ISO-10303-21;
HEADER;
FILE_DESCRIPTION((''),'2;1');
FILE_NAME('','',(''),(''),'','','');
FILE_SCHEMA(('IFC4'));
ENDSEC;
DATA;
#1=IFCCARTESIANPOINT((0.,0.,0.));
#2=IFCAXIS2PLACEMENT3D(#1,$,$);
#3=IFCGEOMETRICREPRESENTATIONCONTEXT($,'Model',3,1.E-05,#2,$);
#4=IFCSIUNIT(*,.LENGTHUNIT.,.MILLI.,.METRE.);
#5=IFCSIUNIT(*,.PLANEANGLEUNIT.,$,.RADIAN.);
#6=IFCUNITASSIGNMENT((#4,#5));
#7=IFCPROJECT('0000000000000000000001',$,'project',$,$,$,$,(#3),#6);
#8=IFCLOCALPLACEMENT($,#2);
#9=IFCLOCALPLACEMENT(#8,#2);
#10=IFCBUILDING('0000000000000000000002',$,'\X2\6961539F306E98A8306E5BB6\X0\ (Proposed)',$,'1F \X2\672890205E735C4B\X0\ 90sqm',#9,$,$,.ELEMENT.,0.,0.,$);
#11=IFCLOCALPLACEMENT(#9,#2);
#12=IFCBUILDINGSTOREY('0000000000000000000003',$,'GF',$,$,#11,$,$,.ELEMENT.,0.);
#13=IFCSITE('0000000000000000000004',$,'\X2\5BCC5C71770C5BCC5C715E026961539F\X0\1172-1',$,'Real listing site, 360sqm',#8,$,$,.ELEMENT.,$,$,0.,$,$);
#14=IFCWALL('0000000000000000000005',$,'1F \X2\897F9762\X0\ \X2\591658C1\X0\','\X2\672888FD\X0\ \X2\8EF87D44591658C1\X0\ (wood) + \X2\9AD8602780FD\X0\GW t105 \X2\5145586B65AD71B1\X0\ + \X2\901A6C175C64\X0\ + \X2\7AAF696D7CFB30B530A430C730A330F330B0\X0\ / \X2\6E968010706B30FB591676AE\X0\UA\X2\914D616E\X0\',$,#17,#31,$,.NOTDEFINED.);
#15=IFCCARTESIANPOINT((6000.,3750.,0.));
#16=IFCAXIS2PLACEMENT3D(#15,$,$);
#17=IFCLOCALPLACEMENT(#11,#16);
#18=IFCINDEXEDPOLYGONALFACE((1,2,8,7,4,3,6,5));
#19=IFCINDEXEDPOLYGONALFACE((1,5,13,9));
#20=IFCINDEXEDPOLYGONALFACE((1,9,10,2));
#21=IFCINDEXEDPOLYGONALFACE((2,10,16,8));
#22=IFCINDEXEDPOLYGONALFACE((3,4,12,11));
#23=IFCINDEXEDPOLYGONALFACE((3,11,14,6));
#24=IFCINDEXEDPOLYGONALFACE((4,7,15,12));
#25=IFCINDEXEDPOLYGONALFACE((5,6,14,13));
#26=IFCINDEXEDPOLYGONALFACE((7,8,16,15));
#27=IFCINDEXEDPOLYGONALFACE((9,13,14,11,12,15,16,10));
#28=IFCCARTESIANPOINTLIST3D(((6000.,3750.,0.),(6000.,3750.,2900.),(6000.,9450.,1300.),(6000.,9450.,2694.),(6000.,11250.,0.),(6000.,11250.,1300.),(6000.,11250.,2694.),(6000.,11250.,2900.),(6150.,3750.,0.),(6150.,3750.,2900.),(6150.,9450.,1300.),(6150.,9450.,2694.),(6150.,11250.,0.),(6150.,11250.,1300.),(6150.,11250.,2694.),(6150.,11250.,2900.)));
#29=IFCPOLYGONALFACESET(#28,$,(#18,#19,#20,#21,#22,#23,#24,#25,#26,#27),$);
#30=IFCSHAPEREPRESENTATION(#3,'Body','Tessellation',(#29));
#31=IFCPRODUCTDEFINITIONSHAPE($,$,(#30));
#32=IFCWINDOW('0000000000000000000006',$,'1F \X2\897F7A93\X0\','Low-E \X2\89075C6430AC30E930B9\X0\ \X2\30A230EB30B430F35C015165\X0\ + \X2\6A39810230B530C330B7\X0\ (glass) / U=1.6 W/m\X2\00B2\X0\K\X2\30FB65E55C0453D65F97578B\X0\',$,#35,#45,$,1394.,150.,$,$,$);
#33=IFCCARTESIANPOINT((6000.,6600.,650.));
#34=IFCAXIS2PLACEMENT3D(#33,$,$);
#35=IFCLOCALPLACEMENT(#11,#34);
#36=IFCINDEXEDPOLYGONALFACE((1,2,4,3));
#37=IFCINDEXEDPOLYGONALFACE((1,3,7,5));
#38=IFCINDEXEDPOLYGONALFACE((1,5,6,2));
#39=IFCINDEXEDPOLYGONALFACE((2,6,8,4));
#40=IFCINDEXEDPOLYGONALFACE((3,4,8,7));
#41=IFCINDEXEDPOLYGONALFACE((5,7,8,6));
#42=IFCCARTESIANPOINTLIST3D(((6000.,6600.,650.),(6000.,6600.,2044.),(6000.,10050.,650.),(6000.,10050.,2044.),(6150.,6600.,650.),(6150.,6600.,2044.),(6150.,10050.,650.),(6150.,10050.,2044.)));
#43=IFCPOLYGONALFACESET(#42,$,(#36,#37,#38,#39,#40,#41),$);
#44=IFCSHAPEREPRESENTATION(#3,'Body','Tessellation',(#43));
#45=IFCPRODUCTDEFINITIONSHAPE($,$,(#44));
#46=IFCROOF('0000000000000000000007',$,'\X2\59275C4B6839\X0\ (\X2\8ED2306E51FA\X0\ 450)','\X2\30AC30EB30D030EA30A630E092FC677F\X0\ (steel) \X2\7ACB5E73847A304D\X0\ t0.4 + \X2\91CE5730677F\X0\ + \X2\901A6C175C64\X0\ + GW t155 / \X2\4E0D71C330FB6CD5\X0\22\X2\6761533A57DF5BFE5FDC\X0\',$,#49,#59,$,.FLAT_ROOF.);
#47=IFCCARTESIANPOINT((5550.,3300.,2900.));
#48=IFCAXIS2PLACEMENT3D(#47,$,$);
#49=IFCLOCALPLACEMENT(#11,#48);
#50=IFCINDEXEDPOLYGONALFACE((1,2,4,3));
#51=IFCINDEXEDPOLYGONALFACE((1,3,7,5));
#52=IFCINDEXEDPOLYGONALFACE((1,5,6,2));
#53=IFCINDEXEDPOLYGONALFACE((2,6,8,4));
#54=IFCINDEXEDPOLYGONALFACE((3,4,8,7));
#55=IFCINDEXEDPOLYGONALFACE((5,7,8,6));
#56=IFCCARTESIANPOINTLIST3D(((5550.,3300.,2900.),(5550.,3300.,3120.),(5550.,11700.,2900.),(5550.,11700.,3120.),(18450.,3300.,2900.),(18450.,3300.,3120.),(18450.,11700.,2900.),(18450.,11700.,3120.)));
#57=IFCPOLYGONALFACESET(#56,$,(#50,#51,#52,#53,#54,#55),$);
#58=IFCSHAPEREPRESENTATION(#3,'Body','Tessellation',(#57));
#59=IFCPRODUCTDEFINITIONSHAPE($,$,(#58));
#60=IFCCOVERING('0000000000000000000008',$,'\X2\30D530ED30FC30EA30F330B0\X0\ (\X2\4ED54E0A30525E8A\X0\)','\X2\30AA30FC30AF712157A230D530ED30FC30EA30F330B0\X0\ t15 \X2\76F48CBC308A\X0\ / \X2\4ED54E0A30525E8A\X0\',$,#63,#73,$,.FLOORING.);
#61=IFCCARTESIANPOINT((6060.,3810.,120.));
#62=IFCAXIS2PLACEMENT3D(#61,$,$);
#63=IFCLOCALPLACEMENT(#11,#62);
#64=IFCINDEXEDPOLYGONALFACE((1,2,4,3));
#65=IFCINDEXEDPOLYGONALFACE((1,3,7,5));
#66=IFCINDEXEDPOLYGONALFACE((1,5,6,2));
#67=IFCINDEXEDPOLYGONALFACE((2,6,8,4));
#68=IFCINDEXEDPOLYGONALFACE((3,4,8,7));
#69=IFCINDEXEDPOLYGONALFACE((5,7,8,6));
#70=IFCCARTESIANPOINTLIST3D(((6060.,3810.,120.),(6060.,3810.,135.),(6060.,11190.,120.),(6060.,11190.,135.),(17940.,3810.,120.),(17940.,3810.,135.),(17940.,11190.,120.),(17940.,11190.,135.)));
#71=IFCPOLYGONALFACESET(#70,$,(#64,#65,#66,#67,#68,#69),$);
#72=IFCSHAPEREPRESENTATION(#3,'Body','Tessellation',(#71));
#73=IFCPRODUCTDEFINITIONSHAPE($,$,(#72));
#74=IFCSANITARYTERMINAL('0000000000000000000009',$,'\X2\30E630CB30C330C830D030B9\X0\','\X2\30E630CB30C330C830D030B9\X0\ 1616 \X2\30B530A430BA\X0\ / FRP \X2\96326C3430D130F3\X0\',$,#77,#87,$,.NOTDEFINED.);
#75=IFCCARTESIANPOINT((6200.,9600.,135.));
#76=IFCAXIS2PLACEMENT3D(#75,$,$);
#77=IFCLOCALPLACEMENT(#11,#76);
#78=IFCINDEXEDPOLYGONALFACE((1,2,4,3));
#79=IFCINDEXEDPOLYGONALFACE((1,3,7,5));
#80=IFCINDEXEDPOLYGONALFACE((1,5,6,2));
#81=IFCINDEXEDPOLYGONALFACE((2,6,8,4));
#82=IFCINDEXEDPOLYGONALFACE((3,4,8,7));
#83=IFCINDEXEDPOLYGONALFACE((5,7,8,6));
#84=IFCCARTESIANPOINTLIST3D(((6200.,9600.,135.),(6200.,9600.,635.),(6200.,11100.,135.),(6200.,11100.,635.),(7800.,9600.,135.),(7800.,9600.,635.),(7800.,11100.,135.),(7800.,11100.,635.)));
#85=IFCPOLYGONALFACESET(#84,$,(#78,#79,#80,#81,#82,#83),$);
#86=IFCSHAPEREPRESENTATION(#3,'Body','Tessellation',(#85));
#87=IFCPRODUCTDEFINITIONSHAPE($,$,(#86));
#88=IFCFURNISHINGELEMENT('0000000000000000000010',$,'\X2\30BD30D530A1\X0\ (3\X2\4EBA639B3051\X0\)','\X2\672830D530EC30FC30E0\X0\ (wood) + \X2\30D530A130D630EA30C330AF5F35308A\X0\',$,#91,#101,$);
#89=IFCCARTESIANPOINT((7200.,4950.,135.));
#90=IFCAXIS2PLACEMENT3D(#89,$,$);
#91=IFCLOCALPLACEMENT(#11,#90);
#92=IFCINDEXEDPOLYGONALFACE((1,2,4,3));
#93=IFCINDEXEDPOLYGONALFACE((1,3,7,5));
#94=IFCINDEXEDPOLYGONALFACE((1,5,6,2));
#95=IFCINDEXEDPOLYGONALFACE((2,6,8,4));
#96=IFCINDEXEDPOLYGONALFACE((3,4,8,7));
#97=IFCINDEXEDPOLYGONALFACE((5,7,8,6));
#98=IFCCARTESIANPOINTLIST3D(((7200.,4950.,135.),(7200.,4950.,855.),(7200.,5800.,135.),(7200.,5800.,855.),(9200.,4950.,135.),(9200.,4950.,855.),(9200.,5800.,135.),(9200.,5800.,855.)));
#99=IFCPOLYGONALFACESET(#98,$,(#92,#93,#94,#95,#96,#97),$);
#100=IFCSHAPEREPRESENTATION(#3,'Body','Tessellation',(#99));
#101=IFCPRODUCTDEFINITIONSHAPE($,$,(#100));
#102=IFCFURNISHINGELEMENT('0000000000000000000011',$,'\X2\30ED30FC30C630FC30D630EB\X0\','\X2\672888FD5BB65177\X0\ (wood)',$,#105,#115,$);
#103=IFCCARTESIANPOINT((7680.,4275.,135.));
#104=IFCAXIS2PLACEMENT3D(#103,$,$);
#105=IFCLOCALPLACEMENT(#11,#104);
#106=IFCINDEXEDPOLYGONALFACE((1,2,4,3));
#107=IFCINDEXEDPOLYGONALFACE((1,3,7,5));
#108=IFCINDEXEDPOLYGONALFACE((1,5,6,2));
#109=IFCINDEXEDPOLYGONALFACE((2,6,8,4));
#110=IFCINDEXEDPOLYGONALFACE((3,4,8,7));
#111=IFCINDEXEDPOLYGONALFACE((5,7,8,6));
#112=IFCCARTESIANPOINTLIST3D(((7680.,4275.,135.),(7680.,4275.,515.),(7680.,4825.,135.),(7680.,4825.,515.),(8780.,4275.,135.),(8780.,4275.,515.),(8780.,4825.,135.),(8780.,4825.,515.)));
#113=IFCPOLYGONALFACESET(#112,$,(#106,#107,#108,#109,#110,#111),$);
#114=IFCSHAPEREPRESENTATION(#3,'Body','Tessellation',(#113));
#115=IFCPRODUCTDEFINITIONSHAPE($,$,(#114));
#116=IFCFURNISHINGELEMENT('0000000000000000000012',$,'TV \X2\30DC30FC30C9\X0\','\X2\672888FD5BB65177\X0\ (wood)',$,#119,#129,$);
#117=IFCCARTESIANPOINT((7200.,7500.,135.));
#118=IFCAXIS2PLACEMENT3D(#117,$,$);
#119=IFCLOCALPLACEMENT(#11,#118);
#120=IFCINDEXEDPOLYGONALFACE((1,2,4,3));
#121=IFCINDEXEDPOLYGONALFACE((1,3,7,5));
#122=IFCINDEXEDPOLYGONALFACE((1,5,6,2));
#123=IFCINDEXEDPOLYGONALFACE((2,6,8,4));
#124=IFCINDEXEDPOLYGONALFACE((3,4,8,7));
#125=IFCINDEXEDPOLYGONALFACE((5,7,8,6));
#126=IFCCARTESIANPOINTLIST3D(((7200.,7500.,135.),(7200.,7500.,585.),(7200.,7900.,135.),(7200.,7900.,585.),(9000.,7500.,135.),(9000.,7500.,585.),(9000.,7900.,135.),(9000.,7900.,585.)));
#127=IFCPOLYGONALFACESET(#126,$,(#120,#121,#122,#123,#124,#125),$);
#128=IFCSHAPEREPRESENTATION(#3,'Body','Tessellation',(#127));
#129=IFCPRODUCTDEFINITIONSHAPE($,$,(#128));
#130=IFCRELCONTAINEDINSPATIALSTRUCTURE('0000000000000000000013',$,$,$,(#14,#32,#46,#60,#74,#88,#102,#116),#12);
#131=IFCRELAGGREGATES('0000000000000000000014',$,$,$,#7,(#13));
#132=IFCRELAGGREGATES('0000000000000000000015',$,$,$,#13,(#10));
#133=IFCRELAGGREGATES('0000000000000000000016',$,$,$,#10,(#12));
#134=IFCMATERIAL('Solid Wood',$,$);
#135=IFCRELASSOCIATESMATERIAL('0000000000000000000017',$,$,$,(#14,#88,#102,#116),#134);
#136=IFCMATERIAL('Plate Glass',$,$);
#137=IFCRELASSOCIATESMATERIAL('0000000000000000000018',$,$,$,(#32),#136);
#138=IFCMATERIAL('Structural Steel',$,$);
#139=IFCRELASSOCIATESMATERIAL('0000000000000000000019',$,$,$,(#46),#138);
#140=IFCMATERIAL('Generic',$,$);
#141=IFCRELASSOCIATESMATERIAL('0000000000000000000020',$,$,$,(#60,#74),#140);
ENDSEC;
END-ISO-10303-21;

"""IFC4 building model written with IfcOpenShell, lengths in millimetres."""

from ifc_helpers import new_model, si_unit, frame, frame_2d, origin, place, context, project, spatial, rectangle, extrude, material, element, fill, save


model = new_model("IFC4")

# Units and contexts
model_context = context("Model", 3, precision=1e-05, world=origin())
ifc_project = project(units=[si_unit("LENGTHUNIT", "METRE", prefix="MILLI"), si_unit("PLANEANGLEUNIT", "RADIAN")], contexts=[model_context])

# Site, building, storey
site_placement = place(None, origin())
site = spatial("IfcSite", under=ifc_project, at=site_placement, Name="富山県富山市楡原1172-1", ObjectType="Real listing site, 360sqm", CompositionType="ELEMENT", RefElevation=0.0)
building_placement = place(site_placement, origin())
building = spatial("IfcBuilding", under=site, at=building_placement, Name="楡原の風の家 (Proposed)", ObjectType="1F 木造平屋 90sqm", CompositionType="ELEMENT", ElevationOfRefHeight=0.0, ElevationOfTerrain=0.0)
storey_placement = place(building_placement, origin())
storey = spatial("IfcBuildingStorey", under=building, at=storey_placement, Name="GF", CompositionType="ELEMENT", Elevation=0.0)

# Shared definitions
ifc_material_1 = material(Name="Solid Wood")

# Shared definitions
ifc_material_2 = material(Name="Plate Glass")

# Wall, opening, window
wall_1_placement = place(storey_placement, frame((6000.0, 3750.0, 0.0)))
wall_1 = element("IfcWall", 1, at=wall_1_placement, inside=storey, material=ifc_material_1, Name="1F 西面 外壁", Description="木製 軸組外壁 (wood) + 高性能GW t105 充填断熱 + 通気層 + 窯業系サイディング / 準耐火・外皮UA配慮", PredefinedType="NOTDEFINED", context=model_context, shape_type="SweptSolid", body=[
    extrude(rectangle(XDim=150.0, YDim=7500.0, at=frame_2d((75.0, 3750.0))), frame((6000.0, 3750.0, 0.0)), (0.0, 0.0, 1.0), 2900.0),
])
opening_1_placement = place(storey_placement, frame((6000.0, 6600.0, 650.0)))
opening_1 = element("IfcOpeningElement", 2, at=opening_1_placement, cuts=wall_1, PredefinedType="NOTDEFINED", context=model_context, shape_type="SweptSolid", body=[
    extrude(rectangle(XDim=150.0, YDim=3450.0, at=frame_2d((75.0, 1725.0))), frame((6000.0, 6600.0, 650.0)), (0.0, 0.0, 1.0), 1394.0),
])
window_1_placement = place(storey_placement, frame((6000.0, 6600.0, 650.0)))
window_1 = element("IfcWindow", 3, at=window_1_placement, inside=storey, material=ifc_material_2, Name="1F 西窓", Description="Low-E 複層ガラス アルゴン封入 + 樹脂サッシ (glass) / U=1.6 W/m²K・日射取得型", OverallHeight=1394.0, OverallWidth=150.0, context=model_context, shape_type="SweptSolid", body=[
    extrude(rectangle(XDim=150.0, YDim=3450.0, at=frame_2d((75.0, 1725.0))), frame((6000.0, 6600.0, 650.0)), (0.0, 0.0, 1.0), 1394.0),
])
fill(opening_1, window_1)

# Roof
ifc_material_3 = material(Name="Structural Steel")
roof_placement = place(storey_placement, frame((5550.0, 3300.0, 2900.0)))
element("IfcRoof", 4, at=roof_placement, inside=storey, material=ifc_material_3, Name="大屋根 (軒の出 450)", Description="ガルバリウム鋼板 (steel) 立平葺き t0.4 + 野地板 + 通気層 + GW t155 / 不燃・法22条区域対応", PredefinedType="FLAT_ROOF", context=model_context, shape_type="SweptSolid", body=[
    extrude(rectangle(XDim=12900.0, YDim=8400.0, at=frame_2d((6450.0, 4200.0))), frame((5550.0, 3300.0, 2900.0)), (0.0, 0.0, 1.0), 220.0),
])

# Covering
ifc_material_4 = material(Name="Generic")
covering_placement = place(storey_placement, frame((6060.0, 3810.0, 120.0)))
element("IfcCovering", 5, at=covering_placement, inside=storey, material=ifc_material_4, Name="フローリング (仕上げ床)", Description="オーク無垢フローリング t15 直貼り / 仕上げ床", PredefinedType="FLOORING", context=model_context, shape_type="SweptSolid", body=[
    extrude(rectangle(XDim=11880.0, YDim=7380.0, at=frame_2d((5940.0, 3690.0))), frame((6060.0, 3810.0, 120.0)), (0.0, 0.0, 1.0), 15.0),
])

# Sanitary terminal
sanitary_terminal_placement = place(storey_placement, frame((6200.0, 9600.0, 135.0)))
element("IfcSanitaryTerminal", 6, at=sanitary_terminal_placement, inside=storey, material=ifc_material_4, Name="ユニットバス", Description="ユニットバス 1616 サイズ / FRP 防水パン", PredefinedType="NOTDEFINED", context=model_context, shape_type="SweptSolid", body=[
    extrude(rectangle(XDim=1600.0, YDim=1500.0, at=frame_2d((800.0, 750.0))), frame((6200.0, 9600.0, 135.0)), (0.0, 0.0, 1.0), 500.0),
])

# Furnishing elements
furnishing_1_placement = place(storey_placement, frame((7200.0, 4950.0, 135.0)))
element("IfcFurnishingElement", 7, at=furnishing_1_placement, inside=storey, material=ifc_material_1, Name="ソファ (3人掛け)", Description="木フレーム (wood) + ファブリック張り", context=model_context, shape_type="SweptSolid", body=[
    extrude(rectangle(XDim=2000.0, YDim=850.0, at=frame_2d((1000.0, 425.0))), frame((7200.0, 4950.0, 135.0)), (0.0, 0.0, 1.0), 720.0),
])
furnishing_2_placement = place(storey_placement, frame((7680.0, 4275.0, 135.0)))
element("IfcFurnishingElement", 8, at=furnishing_2_placement, inside=storey, material=ifc_material_1, Name="ローテーブル", Description="木製家具 (wood)", context=model_context, shape_type="SweptSolid", body=[
    extrude(rectangle(XDim=1100.0, YDim=550.0, at=frame_2d((550.0, 275.0))), frame((7680.0, 4275.0, 135.0)), (0.0, 0.0, 1.0), 380.0),
])
furnishing_3_placement = place(storey_placement, frame((7200.0, 7500.0, 135.0)))
element("IfcFurnishingElement", 9, at=furnishing_3_placement, inside=storey, material=ifc_material_1, Name="TV ボード", Description="木製家具 (wood)", context=model_context, shape_type="SweptSolid", body=[
    extrude(rectangle(XDim=1800.0, YDim=400.0, at=frame_2d((900.0, 200.0))), frame((7200.0, 7500.0, 135.0)), (0.0, 0.0, 1.0), 450.0),
])

save(model, "model.ifc")
